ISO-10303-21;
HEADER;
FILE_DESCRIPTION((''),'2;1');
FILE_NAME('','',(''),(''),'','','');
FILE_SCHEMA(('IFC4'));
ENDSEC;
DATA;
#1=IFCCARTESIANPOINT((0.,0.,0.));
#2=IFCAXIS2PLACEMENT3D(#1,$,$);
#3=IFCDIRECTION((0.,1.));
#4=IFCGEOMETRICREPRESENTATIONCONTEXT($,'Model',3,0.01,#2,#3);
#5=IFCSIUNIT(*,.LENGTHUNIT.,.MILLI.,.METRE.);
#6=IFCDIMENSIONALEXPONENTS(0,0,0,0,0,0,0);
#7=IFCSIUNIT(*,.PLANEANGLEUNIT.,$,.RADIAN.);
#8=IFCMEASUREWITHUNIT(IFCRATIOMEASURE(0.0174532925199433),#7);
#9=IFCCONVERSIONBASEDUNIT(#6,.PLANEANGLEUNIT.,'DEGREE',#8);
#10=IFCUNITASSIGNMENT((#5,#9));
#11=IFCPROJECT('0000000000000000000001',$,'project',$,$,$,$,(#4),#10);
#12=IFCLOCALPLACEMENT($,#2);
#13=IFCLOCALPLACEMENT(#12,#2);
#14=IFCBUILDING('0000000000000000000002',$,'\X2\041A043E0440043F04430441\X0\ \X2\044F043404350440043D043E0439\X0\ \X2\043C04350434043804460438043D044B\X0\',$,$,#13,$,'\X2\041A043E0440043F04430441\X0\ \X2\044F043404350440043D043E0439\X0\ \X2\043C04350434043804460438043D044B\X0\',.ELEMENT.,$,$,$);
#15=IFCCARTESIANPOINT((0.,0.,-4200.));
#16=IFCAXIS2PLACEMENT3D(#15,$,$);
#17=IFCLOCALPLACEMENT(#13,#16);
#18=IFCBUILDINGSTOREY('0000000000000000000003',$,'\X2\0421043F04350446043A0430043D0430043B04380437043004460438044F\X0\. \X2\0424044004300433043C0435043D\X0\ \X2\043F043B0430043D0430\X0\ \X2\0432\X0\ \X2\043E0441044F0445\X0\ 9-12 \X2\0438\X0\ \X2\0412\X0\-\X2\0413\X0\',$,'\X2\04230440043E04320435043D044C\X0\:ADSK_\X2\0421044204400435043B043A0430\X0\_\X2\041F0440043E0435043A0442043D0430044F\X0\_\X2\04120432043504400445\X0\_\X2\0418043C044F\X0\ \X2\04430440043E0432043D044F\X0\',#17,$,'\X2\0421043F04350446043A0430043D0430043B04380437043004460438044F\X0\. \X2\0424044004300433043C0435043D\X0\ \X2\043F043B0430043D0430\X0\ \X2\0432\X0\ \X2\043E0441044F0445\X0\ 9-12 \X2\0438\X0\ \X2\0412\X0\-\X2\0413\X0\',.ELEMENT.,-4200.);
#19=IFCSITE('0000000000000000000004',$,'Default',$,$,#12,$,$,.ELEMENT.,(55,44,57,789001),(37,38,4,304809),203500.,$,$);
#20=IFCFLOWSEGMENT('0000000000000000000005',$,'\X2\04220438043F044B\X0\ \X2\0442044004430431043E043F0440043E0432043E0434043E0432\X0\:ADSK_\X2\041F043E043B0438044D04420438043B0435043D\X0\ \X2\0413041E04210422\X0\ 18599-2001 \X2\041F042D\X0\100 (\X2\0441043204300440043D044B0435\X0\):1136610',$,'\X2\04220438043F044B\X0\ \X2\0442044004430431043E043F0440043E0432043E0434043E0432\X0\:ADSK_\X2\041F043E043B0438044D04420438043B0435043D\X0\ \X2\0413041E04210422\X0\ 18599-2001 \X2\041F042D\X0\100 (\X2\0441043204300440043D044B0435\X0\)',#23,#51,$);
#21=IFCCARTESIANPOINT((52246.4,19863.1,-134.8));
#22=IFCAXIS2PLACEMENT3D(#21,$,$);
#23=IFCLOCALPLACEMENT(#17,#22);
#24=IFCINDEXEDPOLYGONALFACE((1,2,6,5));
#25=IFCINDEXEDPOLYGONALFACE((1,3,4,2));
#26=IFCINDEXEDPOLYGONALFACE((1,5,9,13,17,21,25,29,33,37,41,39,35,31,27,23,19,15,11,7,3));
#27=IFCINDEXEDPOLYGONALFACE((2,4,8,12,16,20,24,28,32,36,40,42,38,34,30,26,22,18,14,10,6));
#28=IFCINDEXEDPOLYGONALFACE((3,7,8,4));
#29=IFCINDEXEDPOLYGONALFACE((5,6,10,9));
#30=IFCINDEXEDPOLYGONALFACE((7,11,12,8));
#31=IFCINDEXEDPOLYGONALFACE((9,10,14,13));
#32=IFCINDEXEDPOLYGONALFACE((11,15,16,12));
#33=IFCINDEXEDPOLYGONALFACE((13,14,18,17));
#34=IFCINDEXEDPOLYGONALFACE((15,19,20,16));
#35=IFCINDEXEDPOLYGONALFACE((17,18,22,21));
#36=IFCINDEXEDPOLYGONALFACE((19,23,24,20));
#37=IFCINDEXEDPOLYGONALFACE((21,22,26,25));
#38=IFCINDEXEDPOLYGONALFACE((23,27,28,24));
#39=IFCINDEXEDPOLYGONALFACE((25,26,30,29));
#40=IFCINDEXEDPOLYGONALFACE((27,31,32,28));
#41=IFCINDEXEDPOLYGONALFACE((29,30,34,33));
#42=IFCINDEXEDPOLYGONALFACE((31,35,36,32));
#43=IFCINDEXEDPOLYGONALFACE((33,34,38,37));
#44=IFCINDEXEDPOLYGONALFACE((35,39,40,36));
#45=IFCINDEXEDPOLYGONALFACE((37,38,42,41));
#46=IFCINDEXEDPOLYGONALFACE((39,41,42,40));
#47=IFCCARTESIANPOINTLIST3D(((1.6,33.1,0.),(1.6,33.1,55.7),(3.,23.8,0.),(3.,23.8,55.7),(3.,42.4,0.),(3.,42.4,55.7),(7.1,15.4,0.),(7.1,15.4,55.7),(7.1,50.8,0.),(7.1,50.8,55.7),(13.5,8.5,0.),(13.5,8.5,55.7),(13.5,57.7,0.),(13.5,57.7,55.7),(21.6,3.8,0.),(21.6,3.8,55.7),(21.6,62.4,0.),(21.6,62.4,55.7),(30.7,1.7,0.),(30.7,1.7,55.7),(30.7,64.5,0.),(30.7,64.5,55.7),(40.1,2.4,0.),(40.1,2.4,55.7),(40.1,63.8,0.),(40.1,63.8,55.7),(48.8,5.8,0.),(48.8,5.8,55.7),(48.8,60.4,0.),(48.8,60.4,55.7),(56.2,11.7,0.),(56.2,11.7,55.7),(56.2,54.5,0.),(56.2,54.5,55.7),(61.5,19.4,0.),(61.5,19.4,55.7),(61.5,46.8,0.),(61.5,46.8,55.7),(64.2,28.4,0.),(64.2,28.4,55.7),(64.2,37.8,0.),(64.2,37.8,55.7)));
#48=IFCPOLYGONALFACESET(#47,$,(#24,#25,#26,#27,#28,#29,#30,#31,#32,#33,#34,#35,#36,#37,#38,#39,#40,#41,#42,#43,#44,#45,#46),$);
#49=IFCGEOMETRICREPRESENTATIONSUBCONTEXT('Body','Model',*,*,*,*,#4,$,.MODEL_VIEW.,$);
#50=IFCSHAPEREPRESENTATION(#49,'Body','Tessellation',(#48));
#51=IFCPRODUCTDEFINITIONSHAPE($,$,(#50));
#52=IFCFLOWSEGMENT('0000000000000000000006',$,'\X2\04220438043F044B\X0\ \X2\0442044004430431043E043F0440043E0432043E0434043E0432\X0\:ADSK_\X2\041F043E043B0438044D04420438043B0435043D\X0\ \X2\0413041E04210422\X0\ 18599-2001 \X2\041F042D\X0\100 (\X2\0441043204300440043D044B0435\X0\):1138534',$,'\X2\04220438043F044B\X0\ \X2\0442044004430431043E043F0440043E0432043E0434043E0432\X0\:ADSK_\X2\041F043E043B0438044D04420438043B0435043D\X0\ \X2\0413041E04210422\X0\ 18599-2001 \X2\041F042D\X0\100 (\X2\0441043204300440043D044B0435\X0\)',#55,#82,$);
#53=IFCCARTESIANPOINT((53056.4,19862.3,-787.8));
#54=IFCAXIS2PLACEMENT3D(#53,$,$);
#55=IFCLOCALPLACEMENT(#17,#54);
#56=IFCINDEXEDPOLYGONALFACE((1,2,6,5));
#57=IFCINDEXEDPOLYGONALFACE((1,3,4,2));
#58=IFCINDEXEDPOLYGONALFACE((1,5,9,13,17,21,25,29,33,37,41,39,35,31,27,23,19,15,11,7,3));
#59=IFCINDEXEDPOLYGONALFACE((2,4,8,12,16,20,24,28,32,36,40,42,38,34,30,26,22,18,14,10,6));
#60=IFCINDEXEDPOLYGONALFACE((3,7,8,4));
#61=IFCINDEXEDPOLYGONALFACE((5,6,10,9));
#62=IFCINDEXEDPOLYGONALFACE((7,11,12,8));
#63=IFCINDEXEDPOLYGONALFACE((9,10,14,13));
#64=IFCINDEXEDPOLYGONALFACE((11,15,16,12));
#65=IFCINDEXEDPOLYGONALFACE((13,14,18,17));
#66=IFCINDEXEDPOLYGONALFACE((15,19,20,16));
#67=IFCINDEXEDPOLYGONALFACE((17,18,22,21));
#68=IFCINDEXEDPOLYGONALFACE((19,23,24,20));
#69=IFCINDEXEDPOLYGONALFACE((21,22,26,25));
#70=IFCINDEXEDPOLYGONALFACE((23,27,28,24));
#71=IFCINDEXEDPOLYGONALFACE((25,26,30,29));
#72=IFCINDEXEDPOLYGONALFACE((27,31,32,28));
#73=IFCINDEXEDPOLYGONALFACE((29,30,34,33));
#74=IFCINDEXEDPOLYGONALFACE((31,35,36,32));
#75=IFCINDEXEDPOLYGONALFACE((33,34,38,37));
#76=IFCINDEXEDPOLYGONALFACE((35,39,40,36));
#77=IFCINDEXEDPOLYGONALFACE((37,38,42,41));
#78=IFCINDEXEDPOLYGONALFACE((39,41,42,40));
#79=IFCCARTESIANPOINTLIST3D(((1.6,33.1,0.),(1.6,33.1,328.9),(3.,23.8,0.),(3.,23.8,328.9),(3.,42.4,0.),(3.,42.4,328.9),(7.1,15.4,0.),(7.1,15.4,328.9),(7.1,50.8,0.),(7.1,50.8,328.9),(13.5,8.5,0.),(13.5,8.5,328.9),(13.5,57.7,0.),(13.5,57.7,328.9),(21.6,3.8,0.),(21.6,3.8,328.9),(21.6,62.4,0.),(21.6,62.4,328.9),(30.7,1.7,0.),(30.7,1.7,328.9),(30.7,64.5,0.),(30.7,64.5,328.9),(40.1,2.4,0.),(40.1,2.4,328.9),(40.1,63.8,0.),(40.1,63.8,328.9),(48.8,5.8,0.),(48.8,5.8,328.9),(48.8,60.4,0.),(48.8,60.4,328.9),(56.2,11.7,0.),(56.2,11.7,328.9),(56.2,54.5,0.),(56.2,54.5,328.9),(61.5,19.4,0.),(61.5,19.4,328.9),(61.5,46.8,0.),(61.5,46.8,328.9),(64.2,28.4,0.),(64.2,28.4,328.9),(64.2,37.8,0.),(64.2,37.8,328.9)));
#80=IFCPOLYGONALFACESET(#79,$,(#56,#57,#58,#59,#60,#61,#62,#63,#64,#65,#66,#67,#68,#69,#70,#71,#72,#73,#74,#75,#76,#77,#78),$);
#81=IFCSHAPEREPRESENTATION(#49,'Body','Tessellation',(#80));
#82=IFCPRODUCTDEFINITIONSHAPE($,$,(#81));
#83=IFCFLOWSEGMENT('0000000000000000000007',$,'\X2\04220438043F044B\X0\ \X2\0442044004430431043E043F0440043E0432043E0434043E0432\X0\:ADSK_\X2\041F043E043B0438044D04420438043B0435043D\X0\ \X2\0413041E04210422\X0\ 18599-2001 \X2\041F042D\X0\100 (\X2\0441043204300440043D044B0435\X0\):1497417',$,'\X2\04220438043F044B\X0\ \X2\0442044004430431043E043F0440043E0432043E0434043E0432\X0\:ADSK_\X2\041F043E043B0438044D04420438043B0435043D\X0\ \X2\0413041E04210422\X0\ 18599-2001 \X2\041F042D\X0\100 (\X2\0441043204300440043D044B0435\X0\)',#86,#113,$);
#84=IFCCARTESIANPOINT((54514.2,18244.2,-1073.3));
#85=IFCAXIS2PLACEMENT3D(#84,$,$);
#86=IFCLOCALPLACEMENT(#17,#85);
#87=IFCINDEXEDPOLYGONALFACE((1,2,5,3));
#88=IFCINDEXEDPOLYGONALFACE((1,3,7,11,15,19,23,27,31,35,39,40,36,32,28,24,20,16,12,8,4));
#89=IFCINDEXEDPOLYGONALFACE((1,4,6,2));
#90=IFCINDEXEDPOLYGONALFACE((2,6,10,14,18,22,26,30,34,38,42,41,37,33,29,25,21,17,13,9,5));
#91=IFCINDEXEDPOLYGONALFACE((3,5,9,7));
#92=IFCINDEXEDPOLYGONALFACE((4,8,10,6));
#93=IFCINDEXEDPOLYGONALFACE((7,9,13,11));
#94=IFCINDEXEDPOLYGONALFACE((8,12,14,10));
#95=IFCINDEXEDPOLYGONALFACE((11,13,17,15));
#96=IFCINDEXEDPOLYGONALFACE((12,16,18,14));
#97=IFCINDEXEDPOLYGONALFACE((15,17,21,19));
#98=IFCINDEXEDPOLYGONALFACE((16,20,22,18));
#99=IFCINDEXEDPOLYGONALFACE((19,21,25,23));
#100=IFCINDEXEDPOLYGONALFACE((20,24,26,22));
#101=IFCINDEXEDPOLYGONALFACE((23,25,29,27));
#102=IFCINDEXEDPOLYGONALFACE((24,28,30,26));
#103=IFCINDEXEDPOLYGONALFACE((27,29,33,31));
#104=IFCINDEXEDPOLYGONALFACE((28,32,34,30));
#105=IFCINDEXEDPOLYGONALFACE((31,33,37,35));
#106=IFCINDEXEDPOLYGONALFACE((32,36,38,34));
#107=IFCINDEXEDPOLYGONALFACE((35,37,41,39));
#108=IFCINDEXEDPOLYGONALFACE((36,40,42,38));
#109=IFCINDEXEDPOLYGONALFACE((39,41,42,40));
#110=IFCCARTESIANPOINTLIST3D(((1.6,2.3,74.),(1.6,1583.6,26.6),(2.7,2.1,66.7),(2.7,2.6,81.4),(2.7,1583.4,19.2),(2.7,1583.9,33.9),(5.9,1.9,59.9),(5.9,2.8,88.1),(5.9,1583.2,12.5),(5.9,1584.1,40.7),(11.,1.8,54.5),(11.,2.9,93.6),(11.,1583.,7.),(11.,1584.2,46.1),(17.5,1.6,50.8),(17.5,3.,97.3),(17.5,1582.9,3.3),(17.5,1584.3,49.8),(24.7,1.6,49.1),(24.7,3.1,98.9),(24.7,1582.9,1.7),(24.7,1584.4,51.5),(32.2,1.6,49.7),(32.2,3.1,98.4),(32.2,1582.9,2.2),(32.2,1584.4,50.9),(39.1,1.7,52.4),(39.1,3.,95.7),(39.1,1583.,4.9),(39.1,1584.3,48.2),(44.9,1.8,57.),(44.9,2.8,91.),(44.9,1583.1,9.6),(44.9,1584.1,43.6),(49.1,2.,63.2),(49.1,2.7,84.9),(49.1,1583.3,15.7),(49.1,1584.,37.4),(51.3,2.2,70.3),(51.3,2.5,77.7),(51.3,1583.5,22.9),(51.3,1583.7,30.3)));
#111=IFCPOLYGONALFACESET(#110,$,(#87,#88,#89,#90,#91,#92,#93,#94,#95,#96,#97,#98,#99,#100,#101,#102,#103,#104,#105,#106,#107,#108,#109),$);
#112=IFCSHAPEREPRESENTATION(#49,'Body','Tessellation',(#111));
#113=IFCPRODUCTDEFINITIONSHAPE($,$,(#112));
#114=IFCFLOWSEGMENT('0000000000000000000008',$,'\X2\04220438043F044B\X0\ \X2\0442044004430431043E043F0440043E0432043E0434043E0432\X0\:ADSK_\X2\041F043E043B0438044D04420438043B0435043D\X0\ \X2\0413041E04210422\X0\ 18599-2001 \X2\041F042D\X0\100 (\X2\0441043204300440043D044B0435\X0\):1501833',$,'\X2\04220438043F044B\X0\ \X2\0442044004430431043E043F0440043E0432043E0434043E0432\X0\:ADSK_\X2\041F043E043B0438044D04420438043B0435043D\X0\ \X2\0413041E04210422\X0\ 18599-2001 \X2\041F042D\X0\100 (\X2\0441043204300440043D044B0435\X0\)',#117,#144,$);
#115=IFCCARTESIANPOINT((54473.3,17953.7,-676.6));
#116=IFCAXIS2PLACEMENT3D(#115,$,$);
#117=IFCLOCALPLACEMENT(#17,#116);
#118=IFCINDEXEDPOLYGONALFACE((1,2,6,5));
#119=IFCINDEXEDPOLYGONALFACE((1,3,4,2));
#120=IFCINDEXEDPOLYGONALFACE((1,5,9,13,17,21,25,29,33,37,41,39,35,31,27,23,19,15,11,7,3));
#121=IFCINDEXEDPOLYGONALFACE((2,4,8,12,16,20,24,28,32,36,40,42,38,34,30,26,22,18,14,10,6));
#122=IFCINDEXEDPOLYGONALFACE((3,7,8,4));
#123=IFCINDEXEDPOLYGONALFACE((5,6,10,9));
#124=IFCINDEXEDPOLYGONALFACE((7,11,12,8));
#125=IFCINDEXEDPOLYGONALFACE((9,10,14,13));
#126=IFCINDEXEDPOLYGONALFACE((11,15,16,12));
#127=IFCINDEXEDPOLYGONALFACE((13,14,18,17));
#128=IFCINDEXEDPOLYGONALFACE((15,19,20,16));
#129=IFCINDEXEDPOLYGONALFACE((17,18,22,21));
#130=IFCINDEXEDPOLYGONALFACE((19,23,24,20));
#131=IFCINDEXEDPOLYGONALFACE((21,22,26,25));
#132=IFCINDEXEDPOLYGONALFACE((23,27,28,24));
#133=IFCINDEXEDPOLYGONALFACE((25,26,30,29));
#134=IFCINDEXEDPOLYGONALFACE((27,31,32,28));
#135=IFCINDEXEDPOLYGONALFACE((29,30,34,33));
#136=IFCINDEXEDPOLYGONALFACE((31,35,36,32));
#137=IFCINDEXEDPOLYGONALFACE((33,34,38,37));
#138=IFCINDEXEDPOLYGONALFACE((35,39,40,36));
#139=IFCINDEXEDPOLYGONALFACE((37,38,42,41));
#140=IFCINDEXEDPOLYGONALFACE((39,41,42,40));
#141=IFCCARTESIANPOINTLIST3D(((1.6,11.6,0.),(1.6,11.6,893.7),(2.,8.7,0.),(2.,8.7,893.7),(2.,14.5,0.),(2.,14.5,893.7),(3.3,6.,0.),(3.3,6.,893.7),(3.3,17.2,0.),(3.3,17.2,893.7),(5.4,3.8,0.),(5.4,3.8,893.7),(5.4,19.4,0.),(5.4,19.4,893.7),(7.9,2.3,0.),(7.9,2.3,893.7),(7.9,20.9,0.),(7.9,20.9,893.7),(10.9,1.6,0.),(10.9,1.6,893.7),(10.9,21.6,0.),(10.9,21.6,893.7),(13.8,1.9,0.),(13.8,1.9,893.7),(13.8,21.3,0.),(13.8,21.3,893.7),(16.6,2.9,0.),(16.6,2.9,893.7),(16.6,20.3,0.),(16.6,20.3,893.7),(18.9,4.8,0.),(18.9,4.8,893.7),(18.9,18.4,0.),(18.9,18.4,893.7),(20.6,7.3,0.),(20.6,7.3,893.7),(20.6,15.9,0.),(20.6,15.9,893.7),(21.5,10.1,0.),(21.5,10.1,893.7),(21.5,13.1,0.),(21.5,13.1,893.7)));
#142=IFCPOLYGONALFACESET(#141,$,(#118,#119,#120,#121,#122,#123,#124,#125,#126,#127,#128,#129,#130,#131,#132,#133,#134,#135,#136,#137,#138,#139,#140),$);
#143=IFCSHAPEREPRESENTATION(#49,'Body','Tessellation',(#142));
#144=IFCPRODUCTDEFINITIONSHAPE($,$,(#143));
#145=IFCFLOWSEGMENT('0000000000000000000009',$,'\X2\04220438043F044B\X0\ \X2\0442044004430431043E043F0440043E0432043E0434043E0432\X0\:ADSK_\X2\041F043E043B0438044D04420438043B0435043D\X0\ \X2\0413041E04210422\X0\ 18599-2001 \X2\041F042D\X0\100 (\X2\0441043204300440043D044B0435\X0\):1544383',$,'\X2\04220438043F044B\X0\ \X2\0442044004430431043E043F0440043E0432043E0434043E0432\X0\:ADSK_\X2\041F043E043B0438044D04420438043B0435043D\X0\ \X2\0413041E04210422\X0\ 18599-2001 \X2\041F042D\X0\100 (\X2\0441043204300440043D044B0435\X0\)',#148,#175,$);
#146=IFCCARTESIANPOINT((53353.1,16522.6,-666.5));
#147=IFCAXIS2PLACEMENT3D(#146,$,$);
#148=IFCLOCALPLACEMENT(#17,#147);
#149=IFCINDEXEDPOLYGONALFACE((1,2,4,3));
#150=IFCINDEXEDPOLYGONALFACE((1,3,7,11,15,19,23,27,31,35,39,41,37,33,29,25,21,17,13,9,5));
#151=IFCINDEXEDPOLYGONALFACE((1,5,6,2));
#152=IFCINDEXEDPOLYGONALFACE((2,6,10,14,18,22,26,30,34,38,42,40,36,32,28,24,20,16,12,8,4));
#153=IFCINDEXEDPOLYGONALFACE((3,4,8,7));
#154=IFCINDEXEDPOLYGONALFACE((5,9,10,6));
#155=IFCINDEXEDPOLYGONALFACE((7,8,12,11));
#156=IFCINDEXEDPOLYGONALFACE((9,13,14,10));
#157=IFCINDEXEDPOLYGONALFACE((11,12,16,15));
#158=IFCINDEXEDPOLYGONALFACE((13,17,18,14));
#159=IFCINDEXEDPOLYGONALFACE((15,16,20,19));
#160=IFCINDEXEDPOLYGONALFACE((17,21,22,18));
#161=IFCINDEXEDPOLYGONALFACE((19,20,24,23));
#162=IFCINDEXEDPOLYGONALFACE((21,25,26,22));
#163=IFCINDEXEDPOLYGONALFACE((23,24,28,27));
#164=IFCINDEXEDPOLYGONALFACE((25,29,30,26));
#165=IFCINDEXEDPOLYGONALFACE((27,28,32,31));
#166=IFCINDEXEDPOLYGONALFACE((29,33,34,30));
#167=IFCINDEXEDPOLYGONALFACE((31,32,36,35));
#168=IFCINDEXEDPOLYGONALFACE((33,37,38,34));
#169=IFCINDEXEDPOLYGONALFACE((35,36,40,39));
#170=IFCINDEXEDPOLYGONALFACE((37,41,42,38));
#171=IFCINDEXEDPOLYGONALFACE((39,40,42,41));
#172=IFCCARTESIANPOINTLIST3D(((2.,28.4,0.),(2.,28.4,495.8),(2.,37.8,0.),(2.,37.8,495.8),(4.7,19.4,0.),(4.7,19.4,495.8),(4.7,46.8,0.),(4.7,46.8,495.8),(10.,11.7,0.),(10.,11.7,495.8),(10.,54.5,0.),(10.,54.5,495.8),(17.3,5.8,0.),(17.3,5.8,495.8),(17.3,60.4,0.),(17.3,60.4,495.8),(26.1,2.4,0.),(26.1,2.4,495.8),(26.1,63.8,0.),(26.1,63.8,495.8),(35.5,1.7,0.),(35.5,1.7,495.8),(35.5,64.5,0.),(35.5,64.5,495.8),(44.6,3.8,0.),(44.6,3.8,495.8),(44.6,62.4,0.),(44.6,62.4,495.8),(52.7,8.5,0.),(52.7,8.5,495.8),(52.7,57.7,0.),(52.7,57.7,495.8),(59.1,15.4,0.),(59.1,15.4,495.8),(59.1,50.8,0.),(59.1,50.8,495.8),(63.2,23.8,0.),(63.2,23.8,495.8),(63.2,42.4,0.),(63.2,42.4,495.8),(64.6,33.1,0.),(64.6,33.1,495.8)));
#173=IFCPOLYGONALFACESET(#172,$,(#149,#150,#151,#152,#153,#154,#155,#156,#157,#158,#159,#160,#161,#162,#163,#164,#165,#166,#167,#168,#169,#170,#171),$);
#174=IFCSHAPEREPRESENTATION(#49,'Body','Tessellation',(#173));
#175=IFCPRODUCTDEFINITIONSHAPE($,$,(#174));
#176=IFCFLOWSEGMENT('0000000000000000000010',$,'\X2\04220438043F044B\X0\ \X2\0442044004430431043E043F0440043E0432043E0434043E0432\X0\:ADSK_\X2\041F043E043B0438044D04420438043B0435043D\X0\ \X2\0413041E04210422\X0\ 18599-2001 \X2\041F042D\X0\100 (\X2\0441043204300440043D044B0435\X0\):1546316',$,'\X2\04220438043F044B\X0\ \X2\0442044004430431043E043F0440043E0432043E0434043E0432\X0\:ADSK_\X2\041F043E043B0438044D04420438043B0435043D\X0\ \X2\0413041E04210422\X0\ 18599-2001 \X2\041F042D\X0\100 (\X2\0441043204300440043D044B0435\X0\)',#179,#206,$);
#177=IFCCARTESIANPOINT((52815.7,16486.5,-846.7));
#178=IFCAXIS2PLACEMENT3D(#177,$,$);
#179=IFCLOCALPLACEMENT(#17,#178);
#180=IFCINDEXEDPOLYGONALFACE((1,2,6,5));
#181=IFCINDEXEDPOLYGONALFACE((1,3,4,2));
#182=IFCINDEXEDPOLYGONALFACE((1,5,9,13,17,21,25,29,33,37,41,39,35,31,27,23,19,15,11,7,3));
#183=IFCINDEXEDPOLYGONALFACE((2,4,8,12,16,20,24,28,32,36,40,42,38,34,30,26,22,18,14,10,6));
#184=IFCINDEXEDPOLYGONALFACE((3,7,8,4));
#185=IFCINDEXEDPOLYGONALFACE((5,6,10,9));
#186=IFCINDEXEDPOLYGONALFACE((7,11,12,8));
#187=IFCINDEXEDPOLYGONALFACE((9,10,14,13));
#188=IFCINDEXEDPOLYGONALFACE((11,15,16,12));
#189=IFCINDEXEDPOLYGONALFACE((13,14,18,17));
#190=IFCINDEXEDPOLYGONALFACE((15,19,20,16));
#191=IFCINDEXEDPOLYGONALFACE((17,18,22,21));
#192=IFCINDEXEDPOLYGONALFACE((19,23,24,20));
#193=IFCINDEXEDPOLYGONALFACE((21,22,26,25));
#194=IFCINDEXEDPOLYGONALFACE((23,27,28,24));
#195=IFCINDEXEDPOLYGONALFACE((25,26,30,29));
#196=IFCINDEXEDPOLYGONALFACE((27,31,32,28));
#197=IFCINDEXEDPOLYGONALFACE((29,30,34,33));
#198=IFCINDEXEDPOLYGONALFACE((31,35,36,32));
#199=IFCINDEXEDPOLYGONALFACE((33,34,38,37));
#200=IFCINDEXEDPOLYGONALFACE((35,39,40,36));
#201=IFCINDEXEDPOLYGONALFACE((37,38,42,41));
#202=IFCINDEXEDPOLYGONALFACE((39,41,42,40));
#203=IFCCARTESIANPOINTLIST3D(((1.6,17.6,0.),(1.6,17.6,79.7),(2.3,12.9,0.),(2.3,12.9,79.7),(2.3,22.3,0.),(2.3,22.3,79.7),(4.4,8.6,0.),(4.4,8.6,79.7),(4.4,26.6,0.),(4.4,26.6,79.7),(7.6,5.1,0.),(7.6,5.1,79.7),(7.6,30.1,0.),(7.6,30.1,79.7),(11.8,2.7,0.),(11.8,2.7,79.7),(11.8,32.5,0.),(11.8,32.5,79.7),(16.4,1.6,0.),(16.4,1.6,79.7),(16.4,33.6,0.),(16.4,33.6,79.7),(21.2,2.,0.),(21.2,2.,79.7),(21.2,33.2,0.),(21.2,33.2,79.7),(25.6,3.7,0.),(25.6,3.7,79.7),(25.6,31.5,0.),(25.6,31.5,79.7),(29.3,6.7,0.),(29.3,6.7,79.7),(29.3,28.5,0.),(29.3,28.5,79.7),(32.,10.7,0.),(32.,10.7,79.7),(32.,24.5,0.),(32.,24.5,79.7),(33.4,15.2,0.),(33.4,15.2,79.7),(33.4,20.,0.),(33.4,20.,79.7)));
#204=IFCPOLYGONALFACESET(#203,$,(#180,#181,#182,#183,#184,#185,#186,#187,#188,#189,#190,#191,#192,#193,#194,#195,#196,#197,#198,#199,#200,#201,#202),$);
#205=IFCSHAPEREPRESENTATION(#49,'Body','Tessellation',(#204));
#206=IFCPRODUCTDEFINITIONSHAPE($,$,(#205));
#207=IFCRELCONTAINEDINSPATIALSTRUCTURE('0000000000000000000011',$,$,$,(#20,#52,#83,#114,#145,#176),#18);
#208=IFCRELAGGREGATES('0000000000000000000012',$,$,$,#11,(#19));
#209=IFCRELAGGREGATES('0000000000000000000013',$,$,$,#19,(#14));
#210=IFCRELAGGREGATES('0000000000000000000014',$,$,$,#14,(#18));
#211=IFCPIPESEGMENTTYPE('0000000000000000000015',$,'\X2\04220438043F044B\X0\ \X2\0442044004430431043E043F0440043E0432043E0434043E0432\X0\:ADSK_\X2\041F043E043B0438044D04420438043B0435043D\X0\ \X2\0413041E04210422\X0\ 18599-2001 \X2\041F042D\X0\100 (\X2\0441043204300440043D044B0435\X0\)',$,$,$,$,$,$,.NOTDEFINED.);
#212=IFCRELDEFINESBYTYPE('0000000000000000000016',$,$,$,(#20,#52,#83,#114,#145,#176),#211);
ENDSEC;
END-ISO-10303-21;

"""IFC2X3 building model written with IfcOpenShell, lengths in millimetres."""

from ifc_helpers import new_model, entity, si_unit, converted_unit, direction, frame, origin, origin_2d_with_axis, place, context, subcontext, project, spatial, circle, extrude, type_object, element, save


model = new_model("IFC2X3")

# Units and contexts
model_context = context("Model", 3, precision=0.01, world=origin(), true_north=direction((0.0, 1.0)))
body_context = subcontext(model_context, "Body", "Model", "MODEL_VIEW")
ifc_project = project(units=[si_unit("LENGTHUNIT", "METRE", prefix="MILLI"), converted_unit("PLANEANGLEUNIT", "DEGREE", entity("IfcRatioMeasure", 0.0174532925199433), si_unit("PLANEANGLEUNIT", "RADIAN"), dimensions=[0, 0, 0, 0, 0, 0, 0])], contexts=[model_context])

# Site, building, storey
site_placement = place(None, origin())
site = spatial("IfcSite", under=ifc_project, at=site_placement, Name="Default", CompositionType="ELEMENT", RefLatitude=(55, 44, 57, 789001), RefLongitude=(37, 38, 4, 304809), RefElevation=203500.0)
building_placement = place(site_placement, origin())
building = spatial("IfcBuilding", under=site, at=building_placement, Name="Корпус ядерной медицины", LongName="Корпус ядерной медицины", CompositionType="ELEMENT")
storey_placement = place(building_placement, frame((0.0, 0.0, -4200.0)))
storey = spatial("IfcBuildingStorey", under=building, at=storey_placement, Name="Спецканализация. Фрагмен плана в осях 9-12 и В-Г", ObjectType="Уровень:ADSK_Стрелка_Проектная_Вверх_Имя уровня", LongName="Спецканализация. Фрагмен плана в осях 9-12 и В-Г", CompositionType="ELEMENT", Elevation=-4200.0)

# Flow segments
pipe_segment_type = type_object("IfcPipeSegmentType", Name="Типы трубопроводов:ADSK_Полиэтилен ГОСТ 18599-2001 ПЭ100 (сварные)", PredefinedType="NOTDEFINED")
flow_segment_1_placement = place(storey_placement, frame((52246.4, 19863.1, -134.8)))
element("IfcFlowSegment", 1, at=flow_segment_1_placement, inside=storey, type_object=pipe_segment_type, Name="Типы трубопроводов:ADSK_Полиэтилен ГОСТ 18599-2001 ПЭ100 (сварные):1136610", ObjectType="Типы трубопроводов:ADSK_Полиэтилен ГОСТ 18599-2001 ПЭ100 (сварные)", context=body_context, shape_type="SweptSolid", body=[
    extrude(circle(Radius=31.5, at=origin_2d_with_axis()), frame((33.1, 33.1, 0.0), z_axis=(0.0, 0.0, 1.0), x_axis=(-1.0, 0.0, 0.0)), (0.0, 0.0, 1.0), 55.7),
])
flow_segment_2_placement = place(storey_placement, frame((53056.4, 19862.3, -787.8)))
element("IfcFlowSegment", 2, at=flow_segment_2_placement, inside=storey, type_object=pipe_segment_type, Name="Типы трубопроводов:ADSK_Полиэтилен ГОСТ 18599-2001 ПЭ100 (сварные):1138534", ObjectType="Типы трубопроводов:ADSK_Полиэтилен ГОСТ 18599-2001 ПЭ100 (сварные)", context=body_context, shape_type="SweptSolid", body=[
    extrude(circle(Radius=31.5, at=origin_2d_with_axis()), frame((33.1, 33.1, 0.0), z_axis=(0.0, 0.0, 1.0), x_axis=(-1.0, 0.0, 0.0)), (0.0, 0.0, 1.0), 328.9),
])
flow_segment_3_placement = place(storey_placement, frame((54514.2, 18244.2, -1073.3)))
element("IfcFlowSegment", 3, at=flow_segment_3_placement, inside=storey, type_object=pipe_segment_type, Name="Типы трубопроводов:ADSK_Полиэтилен ГОСТ 18599-2001 ПЭ100 (сварные):1497417", ObjectType="Типы трубопроводов:ADSK_Полиэтилен ГОСТ 18599-2001 ПЭ100 (сварные)", context=body_context, shape_type="SweptSolid", body=[
    extrude(circle(Radius=25.0, at=origin_2d_with_axis()), frame((26.6, 2.3, 74.0), z_axis=(0.0, 0.99955, -0.029987), x_axis=(-1.0, 0.0, 0.0)), (0.0, 0.0, 1.0), 1582.0),
])
flow_segment_4_placement = place(storey_placement, frame((54473.3, 17953.7, -676.6)))
element("IfcFlowSegment", 4, at=flow_segment_4_placement, inside=storey, type_object=pipe_segment_type, Name="Типы трубопроводов:ADSK_Полиэтилен ГОСТ 18599-2001 ПЭ100 (сварные):1501833", ObjectType="Типы трубопроводов:ADSK_Полиэтилен ГОСТ 18599-2001 ПЭ100 (сварные)", context=body_context, shape_type="SweptSolid", body=[
    extrude(circle(Radius=10.0, at=origin_2d_with_axis()), frame((11.6, 11.6, 0.0), z_axis=(0.0, 0.0, 1.0), x_axis=(-1.0, 0.0, 0.0)), (0.0, 0.0, 1.0), 893.7),
])
flow_segment_5_placement = place(storey_placement, frame((53353.1, 16522.6, -666.5)))
element("IfcFlowSegment", 5, at=flow_segment_5_placement, inside=storey, type_object=pipe_segment_type, Name="Типы трубопроводов:ADSK_Полиэтилен ГОСТ 18599-2001 ПЭ100 (сварные):1544383", ObjectType="Типы трубопроводов:ADSK_Полиэтилен ГОСТ 18599-2001 ПЭ100 (сварные)", context=body_context, shape_type="SweptSolid", body=[
    extrude(circle(Radius=31.5, at=origin_2d_with_axis()), frame((33.1, 33.1, 0.0)), (0.0, 0.0, 1.0), 495.8),
])
flow_segment_6_placement = place(storey_placement, frame((52815.7, 16486.5, -846.7)))
element("IfcFlowSegment", 6, at=flow_segment_6_placement, inside=storey, type_object=pipe_segment_type, Name="Типы трубопроводов:ADSK_Полиэтилен ГОСТ 18599-2001 ПЭ100 (сварные):1546316", ObjectType="Типы трубопроводов:ADSK_Полиэтилен ГОСТ 18599-2001 ПЭ100 (сварные)", context=body_context, shape_type="SweptSolid", body=[
    extrude(circle(Radius=16.0, at=origin_2d_with_axis()), frame((17.6, 17.6, 0.0), z_axis=(0.0, 0.0, 1.0), x_axis=(-1.0, 0.0, 0.0)), (0.0, 0.0, 1.0), 79.7),
])

save(model, "model.ifc")
